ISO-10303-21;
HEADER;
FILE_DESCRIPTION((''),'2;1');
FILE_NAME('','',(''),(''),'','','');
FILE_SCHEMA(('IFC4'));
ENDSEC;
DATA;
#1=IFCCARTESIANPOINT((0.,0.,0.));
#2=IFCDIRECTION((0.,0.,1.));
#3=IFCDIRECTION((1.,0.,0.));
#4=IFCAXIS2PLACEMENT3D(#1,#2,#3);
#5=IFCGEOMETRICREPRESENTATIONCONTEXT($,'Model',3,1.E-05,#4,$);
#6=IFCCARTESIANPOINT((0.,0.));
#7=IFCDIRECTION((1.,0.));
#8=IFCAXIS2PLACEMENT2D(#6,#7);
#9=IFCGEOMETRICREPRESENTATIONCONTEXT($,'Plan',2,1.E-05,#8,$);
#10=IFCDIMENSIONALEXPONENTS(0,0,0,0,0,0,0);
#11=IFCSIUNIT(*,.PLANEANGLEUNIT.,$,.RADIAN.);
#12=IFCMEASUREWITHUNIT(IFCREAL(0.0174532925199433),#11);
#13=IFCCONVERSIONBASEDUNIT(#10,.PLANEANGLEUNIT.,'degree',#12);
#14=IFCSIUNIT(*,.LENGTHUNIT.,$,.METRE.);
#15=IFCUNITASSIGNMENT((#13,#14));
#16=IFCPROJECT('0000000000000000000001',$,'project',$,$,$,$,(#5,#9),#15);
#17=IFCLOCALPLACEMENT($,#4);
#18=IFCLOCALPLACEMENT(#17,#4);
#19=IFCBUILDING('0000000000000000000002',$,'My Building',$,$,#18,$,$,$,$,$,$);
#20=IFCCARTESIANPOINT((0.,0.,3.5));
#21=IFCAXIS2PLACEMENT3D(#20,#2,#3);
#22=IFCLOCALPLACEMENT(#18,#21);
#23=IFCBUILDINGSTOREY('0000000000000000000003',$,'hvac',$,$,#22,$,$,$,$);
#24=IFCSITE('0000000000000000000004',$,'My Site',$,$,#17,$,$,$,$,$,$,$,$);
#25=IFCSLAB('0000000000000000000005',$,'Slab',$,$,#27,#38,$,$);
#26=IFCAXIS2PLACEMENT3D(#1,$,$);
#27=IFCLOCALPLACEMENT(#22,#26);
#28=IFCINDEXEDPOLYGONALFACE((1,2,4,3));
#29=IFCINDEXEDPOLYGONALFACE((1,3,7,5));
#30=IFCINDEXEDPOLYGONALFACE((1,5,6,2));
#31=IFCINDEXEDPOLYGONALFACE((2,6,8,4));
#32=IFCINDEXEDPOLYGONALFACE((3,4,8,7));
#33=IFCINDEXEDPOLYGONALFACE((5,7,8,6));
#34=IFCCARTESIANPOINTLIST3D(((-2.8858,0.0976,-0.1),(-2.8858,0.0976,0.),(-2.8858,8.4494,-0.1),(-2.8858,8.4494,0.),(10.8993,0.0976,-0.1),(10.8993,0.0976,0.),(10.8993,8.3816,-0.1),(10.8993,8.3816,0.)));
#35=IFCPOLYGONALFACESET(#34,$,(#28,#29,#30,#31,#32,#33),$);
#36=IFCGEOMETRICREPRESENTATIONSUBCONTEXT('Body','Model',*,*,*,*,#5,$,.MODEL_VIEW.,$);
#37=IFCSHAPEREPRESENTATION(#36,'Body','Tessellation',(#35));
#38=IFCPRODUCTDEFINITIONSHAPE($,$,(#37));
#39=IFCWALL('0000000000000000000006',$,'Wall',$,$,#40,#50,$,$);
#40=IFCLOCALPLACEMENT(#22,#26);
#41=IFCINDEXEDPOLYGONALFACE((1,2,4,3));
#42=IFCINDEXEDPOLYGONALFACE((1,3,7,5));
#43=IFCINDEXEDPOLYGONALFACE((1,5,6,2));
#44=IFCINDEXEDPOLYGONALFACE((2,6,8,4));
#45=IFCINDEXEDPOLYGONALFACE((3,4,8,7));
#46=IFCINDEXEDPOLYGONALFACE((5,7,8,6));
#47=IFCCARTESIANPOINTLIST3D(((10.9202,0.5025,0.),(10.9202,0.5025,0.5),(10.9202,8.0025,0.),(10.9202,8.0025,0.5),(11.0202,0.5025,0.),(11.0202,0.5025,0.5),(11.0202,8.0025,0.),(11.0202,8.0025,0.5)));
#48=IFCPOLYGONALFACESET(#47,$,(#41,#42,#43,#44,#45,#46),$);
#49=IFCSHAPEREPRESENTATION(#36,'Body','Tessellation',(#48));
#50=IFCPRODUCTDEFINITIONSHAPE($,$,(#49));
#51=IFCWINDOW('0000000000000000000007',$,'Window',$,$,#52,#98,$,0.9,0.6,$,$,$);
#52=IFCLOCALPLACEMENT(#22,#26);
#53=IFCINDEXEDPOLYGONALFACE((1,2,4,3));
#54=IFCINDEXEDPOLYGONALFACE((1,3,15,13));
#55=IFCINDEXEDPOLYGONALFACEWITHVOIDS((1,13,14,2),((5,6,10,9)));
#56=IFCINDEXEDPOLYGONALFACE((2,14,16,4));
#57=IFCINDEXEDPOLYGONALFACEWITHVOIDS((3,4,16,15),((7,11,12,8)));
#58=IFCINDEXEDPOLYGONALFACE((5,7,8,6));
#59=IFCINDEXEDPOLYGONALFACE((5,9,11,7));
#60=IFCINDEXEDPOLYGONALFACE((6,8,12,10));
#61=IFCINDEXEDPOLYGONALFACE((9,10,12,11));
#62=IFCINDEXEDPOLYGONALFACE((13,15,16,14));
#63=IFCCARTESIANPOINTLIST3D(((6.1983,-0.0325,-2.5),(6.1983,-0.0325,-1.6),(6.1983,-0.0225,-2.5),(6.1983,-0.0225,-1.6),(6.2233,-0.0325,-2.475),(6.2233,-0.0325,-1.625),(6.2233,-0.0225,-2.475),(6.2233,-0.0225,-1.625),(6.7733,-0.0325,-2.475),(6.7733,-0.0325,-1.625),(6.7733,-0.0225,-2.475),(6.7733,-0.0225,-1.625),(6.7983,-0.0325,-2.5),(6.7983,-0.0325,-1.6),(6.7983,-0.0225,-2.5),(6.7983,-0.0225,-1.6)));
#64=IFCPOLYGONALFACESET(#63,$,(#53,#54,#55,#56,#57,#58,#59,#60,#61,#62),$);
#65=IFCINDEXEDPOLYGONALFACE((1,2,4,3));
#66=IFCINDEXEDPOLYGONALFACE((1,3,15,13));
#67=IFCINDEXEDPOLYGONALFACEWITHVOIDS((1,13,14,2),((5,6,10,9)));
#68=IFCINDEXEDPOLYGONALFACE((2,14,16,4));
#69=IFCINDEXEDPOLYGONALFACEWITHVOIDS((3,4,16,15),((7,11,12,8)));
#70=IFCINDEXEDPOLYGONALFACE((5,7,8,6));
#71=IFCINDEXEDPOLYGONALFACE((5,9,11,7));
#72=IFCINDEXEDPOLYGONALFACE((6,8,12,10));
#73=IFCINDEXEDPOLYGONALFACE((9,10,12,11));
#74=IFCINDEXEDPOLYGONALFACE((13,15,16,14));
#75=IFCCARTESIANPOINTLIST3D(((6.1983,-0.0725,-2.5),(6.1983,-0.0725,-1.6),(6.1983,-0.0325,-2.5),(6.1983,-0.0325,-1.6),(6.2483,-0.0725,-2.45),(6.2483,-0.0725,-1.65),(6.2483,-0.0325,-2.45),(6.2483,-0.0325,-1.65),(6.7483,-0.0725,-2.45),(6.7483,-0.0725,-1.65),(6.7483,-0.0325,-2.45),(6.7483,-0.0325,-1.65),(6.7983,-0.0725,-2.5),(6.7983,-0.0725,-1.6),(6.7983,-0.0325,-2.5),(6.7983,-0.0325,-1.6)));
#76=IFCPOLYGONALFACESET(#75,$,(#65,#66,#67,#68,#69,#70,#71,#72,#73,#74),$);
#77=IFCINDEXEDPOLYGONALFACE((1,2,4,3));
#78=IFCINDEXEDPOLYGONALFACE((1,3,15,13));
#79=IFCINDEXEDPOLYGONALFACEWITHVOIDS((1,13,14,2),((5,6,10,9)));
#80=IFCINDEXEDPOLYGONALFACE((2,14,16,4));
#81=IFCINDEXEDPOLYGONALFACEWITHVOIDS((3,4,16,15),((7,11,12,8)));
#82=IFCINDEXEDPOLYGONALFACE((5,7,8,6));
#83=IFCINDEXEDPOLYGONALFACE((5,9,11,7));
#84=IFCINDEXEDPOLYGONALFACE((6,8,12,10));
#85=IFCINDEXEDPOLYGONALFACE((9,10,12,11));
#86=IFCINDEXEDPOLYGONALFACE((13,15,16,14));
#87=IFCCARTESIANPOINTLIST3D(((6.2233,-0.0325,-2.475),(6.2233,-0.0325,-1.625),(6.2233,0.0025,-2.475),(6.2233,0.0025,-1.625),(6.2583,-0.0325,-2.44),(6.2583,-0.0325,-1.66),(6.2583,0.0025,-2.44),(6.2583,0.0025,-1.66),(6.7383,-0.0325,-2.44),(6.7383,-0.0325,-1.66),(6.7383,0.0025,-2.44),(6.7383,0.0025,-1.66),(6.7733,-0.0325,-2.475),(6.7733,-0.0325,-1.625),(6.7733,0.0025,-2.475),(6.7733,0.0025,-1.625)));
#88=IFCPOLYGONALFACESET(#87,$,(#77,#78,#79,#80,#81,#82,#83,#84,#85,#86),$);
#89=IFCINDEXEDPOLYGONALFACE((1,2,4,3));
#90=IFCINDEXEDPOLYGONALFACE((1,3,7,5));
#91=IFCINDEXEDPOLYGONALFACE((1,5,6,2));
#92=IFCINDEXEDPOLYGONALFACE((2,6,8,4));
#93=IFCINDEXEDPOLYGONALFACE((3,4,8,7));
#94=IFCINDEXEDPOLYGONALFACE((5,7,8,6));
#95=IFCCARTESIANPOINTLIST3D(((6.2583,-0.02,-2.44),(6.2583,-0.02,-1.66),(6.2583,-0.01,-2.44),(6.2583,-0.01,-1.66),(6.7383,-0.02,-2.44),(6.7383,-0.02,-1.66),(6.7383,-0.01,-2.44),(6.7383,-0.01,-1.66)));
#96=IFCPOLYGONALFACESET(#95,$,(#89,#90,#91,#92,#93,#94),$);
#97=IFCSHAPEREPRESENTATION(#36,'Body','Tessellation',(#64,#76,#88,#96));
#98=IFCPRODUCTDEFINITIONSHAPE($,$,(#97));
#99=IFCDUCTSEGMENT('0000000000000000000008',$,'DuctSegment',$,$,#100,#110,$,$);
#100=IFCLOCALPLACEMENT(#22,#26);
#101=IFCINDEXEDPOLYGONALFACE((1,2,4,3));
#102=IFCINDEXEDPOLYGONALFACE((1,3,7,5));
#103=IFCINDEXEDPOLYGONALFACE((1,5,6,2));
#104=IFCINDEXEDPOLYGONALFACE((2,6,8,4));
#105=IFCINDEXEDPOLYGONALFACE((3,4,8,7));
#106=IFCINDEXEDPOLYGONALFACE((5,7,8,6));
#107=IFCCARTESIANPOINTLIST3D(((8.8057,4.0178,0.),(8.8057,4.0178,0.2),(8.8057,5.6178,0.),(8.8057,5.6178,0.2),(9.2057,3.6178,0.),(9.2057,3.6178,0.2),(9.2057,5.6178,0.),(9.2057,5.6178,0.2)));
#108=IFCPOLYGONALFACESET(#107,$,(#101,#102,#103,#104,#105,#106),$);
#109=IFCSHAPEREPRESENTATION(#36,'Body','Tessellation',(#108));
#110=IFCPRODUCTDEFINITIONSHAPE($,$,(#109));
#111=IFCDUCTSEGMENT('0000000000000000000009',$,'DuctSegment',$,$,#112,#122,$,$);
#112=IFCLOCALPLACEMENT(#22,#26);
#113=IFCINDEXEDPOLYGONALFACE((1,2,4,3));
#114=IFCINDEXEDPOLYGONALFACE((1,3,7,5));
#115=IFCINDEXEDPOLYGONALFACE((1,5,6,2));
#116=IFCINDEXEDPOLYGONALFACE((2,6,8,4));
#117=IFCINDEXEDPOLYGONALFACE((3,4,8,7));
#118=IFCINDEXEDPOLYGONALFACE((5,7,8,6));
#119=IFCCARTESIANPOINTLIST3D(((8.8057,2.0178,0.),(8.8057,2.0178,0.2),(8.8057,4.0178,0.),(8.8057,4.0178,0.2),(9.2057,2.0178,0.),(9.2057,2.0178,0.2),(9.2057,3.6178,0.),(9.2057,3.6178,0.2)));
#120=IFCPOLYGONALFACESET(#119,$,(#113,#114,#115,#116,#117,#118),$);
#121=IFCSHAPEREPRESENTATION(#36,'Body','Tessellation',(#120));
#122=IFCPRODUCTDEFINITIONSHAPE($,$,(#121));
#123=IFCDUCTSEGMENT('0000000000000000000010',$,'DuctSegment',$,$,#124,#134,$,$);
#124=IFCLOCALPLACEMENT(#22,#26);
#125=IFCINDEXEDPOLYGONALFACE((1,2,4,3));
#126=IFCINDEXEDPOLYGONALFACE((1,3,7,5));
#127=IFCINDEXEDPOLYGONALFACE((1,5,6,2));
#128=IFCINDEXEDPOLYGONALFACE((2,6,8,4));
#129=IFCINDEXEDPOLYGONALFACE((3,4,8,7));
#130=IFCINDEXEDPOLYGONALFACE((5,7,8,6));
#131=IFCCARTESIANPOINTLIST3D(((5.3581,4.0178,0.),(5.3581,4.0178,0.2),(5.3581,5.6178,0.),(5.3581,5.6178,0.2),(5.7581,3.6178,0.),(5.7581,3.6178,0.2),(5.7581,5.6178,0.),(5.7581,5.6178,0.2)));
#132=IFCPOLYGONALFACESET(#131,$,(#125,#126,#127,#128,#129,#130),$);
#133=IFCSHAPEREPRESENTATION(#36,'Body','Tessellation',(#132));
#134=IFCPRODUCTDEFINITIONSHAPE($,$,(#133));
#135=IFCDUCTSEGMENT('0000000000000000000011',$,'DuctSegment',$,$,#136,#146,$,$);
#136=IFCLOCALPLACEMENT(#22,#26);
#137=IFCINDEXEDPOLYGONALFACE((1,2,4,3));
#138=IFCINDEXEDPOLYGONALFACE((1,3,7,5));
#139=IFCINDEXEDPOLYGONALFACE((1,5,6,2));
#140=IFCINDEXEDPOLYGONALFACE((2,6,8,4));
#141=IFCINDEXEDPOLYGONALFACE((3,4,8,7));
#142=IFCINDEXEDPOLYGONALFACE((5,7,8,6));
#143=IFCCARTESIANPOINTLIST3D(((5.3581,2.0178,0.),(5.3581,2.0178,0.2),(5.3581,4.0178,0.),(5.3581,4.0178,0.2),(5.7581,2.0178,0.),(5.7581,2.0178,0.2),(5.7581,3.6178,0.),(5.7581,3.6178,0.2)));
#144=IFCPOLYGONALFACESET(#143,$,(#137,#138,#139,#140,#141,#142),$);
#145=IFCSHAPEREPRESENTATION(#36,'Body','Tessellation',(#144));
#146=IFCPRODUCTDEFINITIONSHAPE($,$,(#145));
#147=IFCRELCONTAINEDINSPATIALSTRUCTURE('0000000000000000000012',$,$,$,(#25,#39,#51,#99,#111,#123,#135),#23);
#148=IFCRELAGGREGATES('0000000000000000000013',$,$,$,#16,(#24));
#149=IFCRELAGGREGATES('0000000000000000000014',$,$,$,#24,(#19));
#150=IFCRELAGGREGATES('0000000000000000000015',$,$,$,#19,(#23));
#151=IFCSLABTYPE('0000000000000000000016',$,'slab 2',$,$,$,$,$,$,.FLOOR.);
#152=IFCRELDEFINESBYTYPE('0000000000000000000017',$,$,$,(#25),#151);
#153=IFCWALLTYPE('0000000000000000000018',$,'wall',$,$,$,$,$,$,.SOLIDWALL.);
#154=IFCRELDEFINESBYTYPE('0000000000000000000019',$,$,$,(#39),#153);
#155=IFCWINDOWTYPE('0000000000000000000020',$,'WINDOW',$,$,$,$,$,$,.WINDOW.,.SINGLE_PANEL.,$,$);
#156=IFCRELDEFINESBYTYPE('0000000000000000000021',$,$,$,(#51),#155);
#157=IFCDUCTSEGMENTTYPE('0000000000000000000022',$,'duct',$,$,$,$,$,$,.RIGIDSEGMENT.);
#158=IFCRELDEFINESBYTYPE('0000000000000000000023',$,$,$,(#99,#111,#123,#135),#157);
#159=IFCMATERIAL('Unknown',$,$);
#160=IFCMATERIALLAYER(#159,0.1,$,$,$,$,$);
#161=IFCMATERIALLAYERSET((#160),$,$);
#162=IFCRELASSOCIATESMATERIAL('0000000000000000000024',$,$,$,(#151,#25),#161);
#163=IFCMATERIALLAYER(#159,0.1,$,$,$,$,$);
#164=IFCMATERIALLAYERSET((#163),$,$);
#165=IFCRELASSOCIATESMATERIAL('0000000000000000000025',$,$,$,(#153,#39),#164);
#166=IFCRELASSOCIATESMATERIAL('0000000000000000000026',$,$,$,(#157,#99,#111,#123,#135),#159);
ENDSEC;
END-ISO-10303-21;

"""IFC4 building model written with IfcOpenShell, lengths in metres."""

from ifc_helpers import new_model, entity, si_unit, converted_unit, frame, origin_with_axes, origin_2d_with_axis, place, context, subcontext, project, spatial, line, indexed_curve, rectangle, outline, extrude, clip, halfspace, shape, source, transform, mapped, material, layer, layer_set, layer_usage, material_profile, profile_set, profile_usage, type_object, type_shapes, element, save


model = new_model("IFC4")

# Units and contexts
model_context = context("Model", 3, precision=1e-05, world=origin_with_axes())
plan_context = context("Plan", 2, precision=1e-05, world=origin_2d_with_axis())
body_context_1 = subcontext(model_context, "Body", "Model", "MODEL_VIEW")
body_context_2 = subcontext(plan_context, "Body", "Plan", "PLAN_VIEW")
ifc_project = project(units=[converted_unit("PLANEANGLEUNIT", "degree", entity("IfcReal", 0.0174532925199433), si_unit("PLANEANGLEUNIT", "RADIAN"), dimensions=[0, 0, 0, 0, 0, 0, 0]), si_unit("LENGTHUNIT", "METRE")], contexts=[model_context, plan_context])

# Site, building, storey
site_placement = place(None, origin_with_axes())
site = spatial("IfcSite", under=ifc_project, at=site_placement, Name="My Site")
building_placement = place(site_placement, origin_with_axes())
building = spatial("IfcBuilding", under=site, at=building_placement, Name="My Building")
storey_placement = place(building_placement, frame((0.0, 0.0, 3.5), z_axis=(0.0, 0.0, 1.0), x_axis=(1.0, 0.0, 0.0)))
storey = spatial("IfcBuildingStorey", under=building, at=storey_placement, Name="hvac")

# Slab
ifc_material = material(Name="Unknown")
ifc_layer_1 = layer(ifc_material, 0.1)
ifc_layer_set_1 = layer_set([ifc_layer_1])
ifc_layer_usage_1 = layer_usage(ifc_layer_set_1, "AXIS3", "POSITIVE", -0.1)
slab_type = type_object("IfcSlabType", Name="slab 2", PredefinedType="FLOOR", material=ifc_layer_set_1)
slab_placement = place(storey_placement, frame((10.8993, 8.3816, 0.0), z_axis=(0.0, 0.0, 1.0), x_axis=(1.0, 0.0, 0.0)))
element("IfcSlab", 1, at=slab_placement, inside=storey, type_object=slab_type, material=ifc_layer_usage_1, Name="Slab", context=body_context_1, shape_type="SweptSolid", body=[
    extrude(outline(indexed_curve([(0.0, 0.0), (0.0, -8.284), (-13.7851, -8.284), (-13.7851, 0.0678), (0.0, 0.0)])), frame((0.0, 0.0, -0.1), z_axis=(0.0, 0.0, 1.0), x_axis=(1.0, 0.0, 0.0)), (0.0, 0.0, 1.0), 0.1),
])

# Wall
ifc_layer_2 = layer(ifc_material, 0.1)
ifc_layer_set_2 = layer_set([ifc_layer_2])
ifc_layer_usage_2 = layer_usage(ifc_layer_set_2, "AXIS2", "POSITIVE", 0.0)
wall_type = type_object("IfcWallType", Name="wall", PredefinedType="SOLIDWALL", material=ifc_layer_set_2)
wall_placement = place(storey_placement, frame((10.9202, 8.0025, 0.0), z_axis=(0.0, 0.0, 1.0), x_axis=(0.0, -1.0, 0.0)))
element("IfcWall", 2, at=wall_placement, inside=storey, type_object=wall_type, material=ifc_layer_usage_2, Name="Wall", context=body_context_1, shape_type="SweptSolid", body=[
    extrude(outline(indexed_curve([(0.0, 0.0), (0.0, 0.1), (7.5, 0.1), (7.5, 0.0)], segments=[line(1, 2, 3, 4, 1)])), origin_with_axes(), (0.0, 0.0, 1.0), 0.5),
])

# Window
window_type = type_object("IfcWindowType", Name="WINDOW", PartitioningType="SINGLE_PANEL", PredefinedType="WINDOW")
shared_shape_1 = source(origin_with_axes(), body_context_1, "Body", "SweptSolid", [
    extrude(outline(indexed_curve([(0.0, 0.0), (0.6, 0.0), (0.6, 0.9), (0.0, 0.9)], segments=[line(1, 2, 3, 4, 1)]), holes=[indexed_curve([(0.025, 0.025), (0.575, 0.025), (0.575, 0.875), (0.025, 0.875)], segments=[line(1, 2, 3, 4, 1)])]), frame((0.0, 0.09, 0.0), z_axis=(0.0, -1.0, 0.0), x_axis=(1.0, 0.0, 0.0)), (0.0, 0.0, -1.0), 0.01),
    extrude(outline(indexed_curve([(0.0, 0.0), (0.6, 0.0), (0.6, 0.9), (0.0, 0.9)], segments=[line(1, 2, 3, 4, 1)]), holes=[indexed_curve([(0.05, 0.05), (0.55, 0.05), (0.55, 0.85), (0.05, 0.85)], segments=[line(1, 2, 3, 4, 1)])]), frame((0.0, 0.05, 0.0), z_axis=(0.0, -1.0, 0.0), x_axis=(1.0, 0.0, 0.0)), (0.0, 0.0, -1.0), 0.04),
    extrude(outline(indexed_curve([(0.0, 0.0), (0.55, 0.0), (0.55, 0.85), (0.0, 0.85)], segments=[line(1, 2, 3, 4, 1)]), holes=[indexed_curve([(0.035, 0.035), (0.515, 0.035), (0.515, 0.815), (0.035, 0.815)], segments=[line(1, 2, 3, 4, 1)])]), frame((0.025, 0.09, 0.025), z_axis=(0.0, -1.0, 0.0), x_axis=(1.0, 0.0, 0.0)), (0.0, 0.0, -1.0), 0.035),
    extrude(outline(indexed_curve([(0.035, 0.035), (0.515, 0.035), (0.515, 0.815), (0.035, 0.815)], segments=[line(1, 2, 3, 4, 1)])), frame((0.025, 0.1025, 0.025), z_axis=(0.0, -1.0, 0.0), x_axis=(1.0, 0.0, 0.0)), (0.0, 0.0, -1.0), 0.01),
])
shared_shape_2 = source(origin_with_axes(), body_context_2, "Body", "Curve2D", [
    entity("IfcIndexedPolyCurve", entity("IfcCartesianPointList2D", [[0.05, 0.05], [0.55, 0.05]])),
    entity("IfcIndexedPolyCurve", entity("IfcCartesianPointList2D", [[0.0, 0.1], [0.025, 0.1], [0.025, 0.09], [0.05, 0.09], [0.05, 0.05], [0.0, 0.05]]), [entity("IfcLineIndex", [1, 2, 3, 4, 5, 6, 1])]),
    entity("IfcIndexedPolyCurve", entity("IfcCartesianPointList2D", [[0.6, 0.1], [0.575, 0.1], [0.575, 0.09], [0.55, 0.09], [0.55, 0.05], [0.6, 0.05]]), [entity("IfcLineIndex", [1, 2, 3, 4, 5, 6, 1])]),
    entity("IfcIndexedPolyCurve", entity("IfcCartesianPointList2D", [[0.025, 0.09], [0.06, 0.09], [0.06, 0.125], [0.025, 0.125]]), [entity("IfcLineIndex", [1, 2, 3, 4, 1])]),
    entity("IfcIndexedPolyCurve", entity("IfcCartesianPointList2D", [[0.575, 0.09], [0.54, 0.09], [0.54, 0.125], [0.575, 0.125]]), [entity("IfcLineIndex", [1, 2, 3, 4, 1])]),
    entity("IfcIndexedPolyCurve", entity("IfcCartesianPointList2D", [[0.06, 0.09], [0.54, 0.09]])),
    entity("IfcIndexedPolyCurve", entity("IfcCartesianPointList2D", [[0.06, 0.125], [0.54, 0.125]])),
    entity("IfcIndexedPolyCurve", entity("IfcCartesianPointList2D", [[0.06, 0.1075], [0.54, 0.1075]])),
])
type_shapes(window_type, [shared_shape_1, shared_shape_2])
window_placement = place(storey_placement, frame((6.1983, -0.1225, -2.5), z_axis=(0.0, 0.0, 1.0), x_axis=(1.0, 0.0, 0.0)))
element("IfcWindow", 3, at=window_placement, inside=storey, type_object=window_type, Name="Window", OverallHeight=0.9, OverallWidth=0.6, shapes=[
    shape(body_context_1, "Body", "MappedRepresentation", [mapped(shared_shape_1, transform((0.0, 0.0, 0.0), x_axis=(1.0, 0.0, 0.0), y_axis=(0.0, 1.0, 0.0), z_axis=(0.0, 0.0, 1.0), scale=1.0))]),
    shape(body_context_2, "Body", "MappedRepresentation", [mapped(shared_shape_2, transform((0.0, 0.0, 0.0), x_axis=(1.0, 0.0, 0.0), y_axis=(0.0, 1.0, 0.0), z_axis=(0.0, 0.0, 1.0), scale=1.0))]),
])

# Duct segments
ifc_material_profile_1 = material_profile(ifc_material, rectangle(XDim=0.4, YDim=0.2))
ifc_profile_set_1 = profile_set([ifc_material_profile_1])
ifc_profile_usage_1 = profile_usage(ifc_profile_set_1, cardinal=5)
duct_segment_type = type_object("IfcDuctSegmentType", Name="duct", PredefinedType="RIGIDSEGMENT", material=ifc_profile_set_1)
duct_segment_1_placement = place(storey_placement, frame((9.0057, 3.6178, 0.1), z_axis=(0.0, 1.0, 0.0), x_axis=(-1.0, 0.0, 0.0)))
element("IfcDuctSegment", 4, at=duct_segment_1_placement, inside=storey, type_object=duct_segment_type, material=ifc_profile_usage_1, Name="DuctSegment", context=body_context_1, shape_type="Clipping", body=[
    clip(extrude(rectangle(XDim=0.4, YDim=0.2), origin_with_axes(), (0.0, 0.0, 1.0), 2.0), halfspace(frame((-0.2, 0.0, 0.0), z_axis=(0.707107, 0.0, -0.707107), x_axis=(0.0, -1.0, 0.0)), False)),
])
ifc_profile_usage_2 = profile_usage(ifc_profile_set_1, cardinal=5)
duct_segment_2_placement = place(storey_placement, frame((9.0057, 4.0178, 0.1), z_axis=(0.0, -1.0, 0.0), x_axis=(1.0, 0.0, 0.0)))
element("IfcDuctSegment", 5, at=duct_segment_2_placement, inside=storey, type_object=duct_segment_type, material=ifc_profile_usage_2, Name="DuctSegment", context=body_context_1, shape_type="Clipping", body=[
    clip(extrude(rectangle(XDim=0.4, YDim=0.2), origin_with_axes(), (0.0, 0.0, 1.0), 2.0), halfspace(frame((-0.2, 0.0, 0.0), z_axis=(0.707107, 0.0, -0.707107), x_axis=(0.0, -1.0, 0.0)), False)),
])
ifc_profile_usage_3 = profile_usage(ifc_profile_set_1, cardinal=5)
duct_segment_3_placement = place(storey_placement, frame((5.5581, 3.6178, 0.1), z_axis=(0.0, 1.0, 0.0), x_axis=(-1.0, 0.0, 0.0)))
element("IfcDuctSegment", 6, at=duct_segment_3_placement, inside=storey, type_object=duct_segment_type, material=ifc_profile_usage_3, Name="DuctSegment", context=body_context_1, shape_type="Clipping", body=[
    clip(extrude(rectangle(XDim=0.4, YDim=0.2), origin_with_axes(), (0.0, 0.0, 1.0), 2.0), halfspace(frame((-0.2, 0.0, 0.0), z_axis=(0.707107, 0.0, -0.707107), x_axis=(0.0, -1.0, 0.0)), False)),
])
ifc_profile_usage_4 = profile_usage(ifc_profile_set_1, cardinal=5)
duct_segment_4_placement = place(storey_placement, frame((5.5581, 4.0178, 0.1), z_axis=(0.0, -1.0, 0.0), x_axis=(1.0, 0.0, 0.0)))
element("IfcDuctSegment", 7, at=duct_segment_4_placement, inside=storey, type_object=duct_segment_type, material=ifc_profile_usage_4, Name="DuctSegment", context=body_context_1, shape_type="Clipping", body=[
    clip(extrude(rectangle(XDim=0.4, YDim=0.2), origin_with_axes(), (0.0, 0.0, 1.0), 2.0), halfspace(frame((-0.2, 0.0, 0.0), z_axis=(0.707107, 0.0, -0.707107), x_axis=(0.0, -1.0, 0.0)), False)),
])

save(model, "model.ifc")
